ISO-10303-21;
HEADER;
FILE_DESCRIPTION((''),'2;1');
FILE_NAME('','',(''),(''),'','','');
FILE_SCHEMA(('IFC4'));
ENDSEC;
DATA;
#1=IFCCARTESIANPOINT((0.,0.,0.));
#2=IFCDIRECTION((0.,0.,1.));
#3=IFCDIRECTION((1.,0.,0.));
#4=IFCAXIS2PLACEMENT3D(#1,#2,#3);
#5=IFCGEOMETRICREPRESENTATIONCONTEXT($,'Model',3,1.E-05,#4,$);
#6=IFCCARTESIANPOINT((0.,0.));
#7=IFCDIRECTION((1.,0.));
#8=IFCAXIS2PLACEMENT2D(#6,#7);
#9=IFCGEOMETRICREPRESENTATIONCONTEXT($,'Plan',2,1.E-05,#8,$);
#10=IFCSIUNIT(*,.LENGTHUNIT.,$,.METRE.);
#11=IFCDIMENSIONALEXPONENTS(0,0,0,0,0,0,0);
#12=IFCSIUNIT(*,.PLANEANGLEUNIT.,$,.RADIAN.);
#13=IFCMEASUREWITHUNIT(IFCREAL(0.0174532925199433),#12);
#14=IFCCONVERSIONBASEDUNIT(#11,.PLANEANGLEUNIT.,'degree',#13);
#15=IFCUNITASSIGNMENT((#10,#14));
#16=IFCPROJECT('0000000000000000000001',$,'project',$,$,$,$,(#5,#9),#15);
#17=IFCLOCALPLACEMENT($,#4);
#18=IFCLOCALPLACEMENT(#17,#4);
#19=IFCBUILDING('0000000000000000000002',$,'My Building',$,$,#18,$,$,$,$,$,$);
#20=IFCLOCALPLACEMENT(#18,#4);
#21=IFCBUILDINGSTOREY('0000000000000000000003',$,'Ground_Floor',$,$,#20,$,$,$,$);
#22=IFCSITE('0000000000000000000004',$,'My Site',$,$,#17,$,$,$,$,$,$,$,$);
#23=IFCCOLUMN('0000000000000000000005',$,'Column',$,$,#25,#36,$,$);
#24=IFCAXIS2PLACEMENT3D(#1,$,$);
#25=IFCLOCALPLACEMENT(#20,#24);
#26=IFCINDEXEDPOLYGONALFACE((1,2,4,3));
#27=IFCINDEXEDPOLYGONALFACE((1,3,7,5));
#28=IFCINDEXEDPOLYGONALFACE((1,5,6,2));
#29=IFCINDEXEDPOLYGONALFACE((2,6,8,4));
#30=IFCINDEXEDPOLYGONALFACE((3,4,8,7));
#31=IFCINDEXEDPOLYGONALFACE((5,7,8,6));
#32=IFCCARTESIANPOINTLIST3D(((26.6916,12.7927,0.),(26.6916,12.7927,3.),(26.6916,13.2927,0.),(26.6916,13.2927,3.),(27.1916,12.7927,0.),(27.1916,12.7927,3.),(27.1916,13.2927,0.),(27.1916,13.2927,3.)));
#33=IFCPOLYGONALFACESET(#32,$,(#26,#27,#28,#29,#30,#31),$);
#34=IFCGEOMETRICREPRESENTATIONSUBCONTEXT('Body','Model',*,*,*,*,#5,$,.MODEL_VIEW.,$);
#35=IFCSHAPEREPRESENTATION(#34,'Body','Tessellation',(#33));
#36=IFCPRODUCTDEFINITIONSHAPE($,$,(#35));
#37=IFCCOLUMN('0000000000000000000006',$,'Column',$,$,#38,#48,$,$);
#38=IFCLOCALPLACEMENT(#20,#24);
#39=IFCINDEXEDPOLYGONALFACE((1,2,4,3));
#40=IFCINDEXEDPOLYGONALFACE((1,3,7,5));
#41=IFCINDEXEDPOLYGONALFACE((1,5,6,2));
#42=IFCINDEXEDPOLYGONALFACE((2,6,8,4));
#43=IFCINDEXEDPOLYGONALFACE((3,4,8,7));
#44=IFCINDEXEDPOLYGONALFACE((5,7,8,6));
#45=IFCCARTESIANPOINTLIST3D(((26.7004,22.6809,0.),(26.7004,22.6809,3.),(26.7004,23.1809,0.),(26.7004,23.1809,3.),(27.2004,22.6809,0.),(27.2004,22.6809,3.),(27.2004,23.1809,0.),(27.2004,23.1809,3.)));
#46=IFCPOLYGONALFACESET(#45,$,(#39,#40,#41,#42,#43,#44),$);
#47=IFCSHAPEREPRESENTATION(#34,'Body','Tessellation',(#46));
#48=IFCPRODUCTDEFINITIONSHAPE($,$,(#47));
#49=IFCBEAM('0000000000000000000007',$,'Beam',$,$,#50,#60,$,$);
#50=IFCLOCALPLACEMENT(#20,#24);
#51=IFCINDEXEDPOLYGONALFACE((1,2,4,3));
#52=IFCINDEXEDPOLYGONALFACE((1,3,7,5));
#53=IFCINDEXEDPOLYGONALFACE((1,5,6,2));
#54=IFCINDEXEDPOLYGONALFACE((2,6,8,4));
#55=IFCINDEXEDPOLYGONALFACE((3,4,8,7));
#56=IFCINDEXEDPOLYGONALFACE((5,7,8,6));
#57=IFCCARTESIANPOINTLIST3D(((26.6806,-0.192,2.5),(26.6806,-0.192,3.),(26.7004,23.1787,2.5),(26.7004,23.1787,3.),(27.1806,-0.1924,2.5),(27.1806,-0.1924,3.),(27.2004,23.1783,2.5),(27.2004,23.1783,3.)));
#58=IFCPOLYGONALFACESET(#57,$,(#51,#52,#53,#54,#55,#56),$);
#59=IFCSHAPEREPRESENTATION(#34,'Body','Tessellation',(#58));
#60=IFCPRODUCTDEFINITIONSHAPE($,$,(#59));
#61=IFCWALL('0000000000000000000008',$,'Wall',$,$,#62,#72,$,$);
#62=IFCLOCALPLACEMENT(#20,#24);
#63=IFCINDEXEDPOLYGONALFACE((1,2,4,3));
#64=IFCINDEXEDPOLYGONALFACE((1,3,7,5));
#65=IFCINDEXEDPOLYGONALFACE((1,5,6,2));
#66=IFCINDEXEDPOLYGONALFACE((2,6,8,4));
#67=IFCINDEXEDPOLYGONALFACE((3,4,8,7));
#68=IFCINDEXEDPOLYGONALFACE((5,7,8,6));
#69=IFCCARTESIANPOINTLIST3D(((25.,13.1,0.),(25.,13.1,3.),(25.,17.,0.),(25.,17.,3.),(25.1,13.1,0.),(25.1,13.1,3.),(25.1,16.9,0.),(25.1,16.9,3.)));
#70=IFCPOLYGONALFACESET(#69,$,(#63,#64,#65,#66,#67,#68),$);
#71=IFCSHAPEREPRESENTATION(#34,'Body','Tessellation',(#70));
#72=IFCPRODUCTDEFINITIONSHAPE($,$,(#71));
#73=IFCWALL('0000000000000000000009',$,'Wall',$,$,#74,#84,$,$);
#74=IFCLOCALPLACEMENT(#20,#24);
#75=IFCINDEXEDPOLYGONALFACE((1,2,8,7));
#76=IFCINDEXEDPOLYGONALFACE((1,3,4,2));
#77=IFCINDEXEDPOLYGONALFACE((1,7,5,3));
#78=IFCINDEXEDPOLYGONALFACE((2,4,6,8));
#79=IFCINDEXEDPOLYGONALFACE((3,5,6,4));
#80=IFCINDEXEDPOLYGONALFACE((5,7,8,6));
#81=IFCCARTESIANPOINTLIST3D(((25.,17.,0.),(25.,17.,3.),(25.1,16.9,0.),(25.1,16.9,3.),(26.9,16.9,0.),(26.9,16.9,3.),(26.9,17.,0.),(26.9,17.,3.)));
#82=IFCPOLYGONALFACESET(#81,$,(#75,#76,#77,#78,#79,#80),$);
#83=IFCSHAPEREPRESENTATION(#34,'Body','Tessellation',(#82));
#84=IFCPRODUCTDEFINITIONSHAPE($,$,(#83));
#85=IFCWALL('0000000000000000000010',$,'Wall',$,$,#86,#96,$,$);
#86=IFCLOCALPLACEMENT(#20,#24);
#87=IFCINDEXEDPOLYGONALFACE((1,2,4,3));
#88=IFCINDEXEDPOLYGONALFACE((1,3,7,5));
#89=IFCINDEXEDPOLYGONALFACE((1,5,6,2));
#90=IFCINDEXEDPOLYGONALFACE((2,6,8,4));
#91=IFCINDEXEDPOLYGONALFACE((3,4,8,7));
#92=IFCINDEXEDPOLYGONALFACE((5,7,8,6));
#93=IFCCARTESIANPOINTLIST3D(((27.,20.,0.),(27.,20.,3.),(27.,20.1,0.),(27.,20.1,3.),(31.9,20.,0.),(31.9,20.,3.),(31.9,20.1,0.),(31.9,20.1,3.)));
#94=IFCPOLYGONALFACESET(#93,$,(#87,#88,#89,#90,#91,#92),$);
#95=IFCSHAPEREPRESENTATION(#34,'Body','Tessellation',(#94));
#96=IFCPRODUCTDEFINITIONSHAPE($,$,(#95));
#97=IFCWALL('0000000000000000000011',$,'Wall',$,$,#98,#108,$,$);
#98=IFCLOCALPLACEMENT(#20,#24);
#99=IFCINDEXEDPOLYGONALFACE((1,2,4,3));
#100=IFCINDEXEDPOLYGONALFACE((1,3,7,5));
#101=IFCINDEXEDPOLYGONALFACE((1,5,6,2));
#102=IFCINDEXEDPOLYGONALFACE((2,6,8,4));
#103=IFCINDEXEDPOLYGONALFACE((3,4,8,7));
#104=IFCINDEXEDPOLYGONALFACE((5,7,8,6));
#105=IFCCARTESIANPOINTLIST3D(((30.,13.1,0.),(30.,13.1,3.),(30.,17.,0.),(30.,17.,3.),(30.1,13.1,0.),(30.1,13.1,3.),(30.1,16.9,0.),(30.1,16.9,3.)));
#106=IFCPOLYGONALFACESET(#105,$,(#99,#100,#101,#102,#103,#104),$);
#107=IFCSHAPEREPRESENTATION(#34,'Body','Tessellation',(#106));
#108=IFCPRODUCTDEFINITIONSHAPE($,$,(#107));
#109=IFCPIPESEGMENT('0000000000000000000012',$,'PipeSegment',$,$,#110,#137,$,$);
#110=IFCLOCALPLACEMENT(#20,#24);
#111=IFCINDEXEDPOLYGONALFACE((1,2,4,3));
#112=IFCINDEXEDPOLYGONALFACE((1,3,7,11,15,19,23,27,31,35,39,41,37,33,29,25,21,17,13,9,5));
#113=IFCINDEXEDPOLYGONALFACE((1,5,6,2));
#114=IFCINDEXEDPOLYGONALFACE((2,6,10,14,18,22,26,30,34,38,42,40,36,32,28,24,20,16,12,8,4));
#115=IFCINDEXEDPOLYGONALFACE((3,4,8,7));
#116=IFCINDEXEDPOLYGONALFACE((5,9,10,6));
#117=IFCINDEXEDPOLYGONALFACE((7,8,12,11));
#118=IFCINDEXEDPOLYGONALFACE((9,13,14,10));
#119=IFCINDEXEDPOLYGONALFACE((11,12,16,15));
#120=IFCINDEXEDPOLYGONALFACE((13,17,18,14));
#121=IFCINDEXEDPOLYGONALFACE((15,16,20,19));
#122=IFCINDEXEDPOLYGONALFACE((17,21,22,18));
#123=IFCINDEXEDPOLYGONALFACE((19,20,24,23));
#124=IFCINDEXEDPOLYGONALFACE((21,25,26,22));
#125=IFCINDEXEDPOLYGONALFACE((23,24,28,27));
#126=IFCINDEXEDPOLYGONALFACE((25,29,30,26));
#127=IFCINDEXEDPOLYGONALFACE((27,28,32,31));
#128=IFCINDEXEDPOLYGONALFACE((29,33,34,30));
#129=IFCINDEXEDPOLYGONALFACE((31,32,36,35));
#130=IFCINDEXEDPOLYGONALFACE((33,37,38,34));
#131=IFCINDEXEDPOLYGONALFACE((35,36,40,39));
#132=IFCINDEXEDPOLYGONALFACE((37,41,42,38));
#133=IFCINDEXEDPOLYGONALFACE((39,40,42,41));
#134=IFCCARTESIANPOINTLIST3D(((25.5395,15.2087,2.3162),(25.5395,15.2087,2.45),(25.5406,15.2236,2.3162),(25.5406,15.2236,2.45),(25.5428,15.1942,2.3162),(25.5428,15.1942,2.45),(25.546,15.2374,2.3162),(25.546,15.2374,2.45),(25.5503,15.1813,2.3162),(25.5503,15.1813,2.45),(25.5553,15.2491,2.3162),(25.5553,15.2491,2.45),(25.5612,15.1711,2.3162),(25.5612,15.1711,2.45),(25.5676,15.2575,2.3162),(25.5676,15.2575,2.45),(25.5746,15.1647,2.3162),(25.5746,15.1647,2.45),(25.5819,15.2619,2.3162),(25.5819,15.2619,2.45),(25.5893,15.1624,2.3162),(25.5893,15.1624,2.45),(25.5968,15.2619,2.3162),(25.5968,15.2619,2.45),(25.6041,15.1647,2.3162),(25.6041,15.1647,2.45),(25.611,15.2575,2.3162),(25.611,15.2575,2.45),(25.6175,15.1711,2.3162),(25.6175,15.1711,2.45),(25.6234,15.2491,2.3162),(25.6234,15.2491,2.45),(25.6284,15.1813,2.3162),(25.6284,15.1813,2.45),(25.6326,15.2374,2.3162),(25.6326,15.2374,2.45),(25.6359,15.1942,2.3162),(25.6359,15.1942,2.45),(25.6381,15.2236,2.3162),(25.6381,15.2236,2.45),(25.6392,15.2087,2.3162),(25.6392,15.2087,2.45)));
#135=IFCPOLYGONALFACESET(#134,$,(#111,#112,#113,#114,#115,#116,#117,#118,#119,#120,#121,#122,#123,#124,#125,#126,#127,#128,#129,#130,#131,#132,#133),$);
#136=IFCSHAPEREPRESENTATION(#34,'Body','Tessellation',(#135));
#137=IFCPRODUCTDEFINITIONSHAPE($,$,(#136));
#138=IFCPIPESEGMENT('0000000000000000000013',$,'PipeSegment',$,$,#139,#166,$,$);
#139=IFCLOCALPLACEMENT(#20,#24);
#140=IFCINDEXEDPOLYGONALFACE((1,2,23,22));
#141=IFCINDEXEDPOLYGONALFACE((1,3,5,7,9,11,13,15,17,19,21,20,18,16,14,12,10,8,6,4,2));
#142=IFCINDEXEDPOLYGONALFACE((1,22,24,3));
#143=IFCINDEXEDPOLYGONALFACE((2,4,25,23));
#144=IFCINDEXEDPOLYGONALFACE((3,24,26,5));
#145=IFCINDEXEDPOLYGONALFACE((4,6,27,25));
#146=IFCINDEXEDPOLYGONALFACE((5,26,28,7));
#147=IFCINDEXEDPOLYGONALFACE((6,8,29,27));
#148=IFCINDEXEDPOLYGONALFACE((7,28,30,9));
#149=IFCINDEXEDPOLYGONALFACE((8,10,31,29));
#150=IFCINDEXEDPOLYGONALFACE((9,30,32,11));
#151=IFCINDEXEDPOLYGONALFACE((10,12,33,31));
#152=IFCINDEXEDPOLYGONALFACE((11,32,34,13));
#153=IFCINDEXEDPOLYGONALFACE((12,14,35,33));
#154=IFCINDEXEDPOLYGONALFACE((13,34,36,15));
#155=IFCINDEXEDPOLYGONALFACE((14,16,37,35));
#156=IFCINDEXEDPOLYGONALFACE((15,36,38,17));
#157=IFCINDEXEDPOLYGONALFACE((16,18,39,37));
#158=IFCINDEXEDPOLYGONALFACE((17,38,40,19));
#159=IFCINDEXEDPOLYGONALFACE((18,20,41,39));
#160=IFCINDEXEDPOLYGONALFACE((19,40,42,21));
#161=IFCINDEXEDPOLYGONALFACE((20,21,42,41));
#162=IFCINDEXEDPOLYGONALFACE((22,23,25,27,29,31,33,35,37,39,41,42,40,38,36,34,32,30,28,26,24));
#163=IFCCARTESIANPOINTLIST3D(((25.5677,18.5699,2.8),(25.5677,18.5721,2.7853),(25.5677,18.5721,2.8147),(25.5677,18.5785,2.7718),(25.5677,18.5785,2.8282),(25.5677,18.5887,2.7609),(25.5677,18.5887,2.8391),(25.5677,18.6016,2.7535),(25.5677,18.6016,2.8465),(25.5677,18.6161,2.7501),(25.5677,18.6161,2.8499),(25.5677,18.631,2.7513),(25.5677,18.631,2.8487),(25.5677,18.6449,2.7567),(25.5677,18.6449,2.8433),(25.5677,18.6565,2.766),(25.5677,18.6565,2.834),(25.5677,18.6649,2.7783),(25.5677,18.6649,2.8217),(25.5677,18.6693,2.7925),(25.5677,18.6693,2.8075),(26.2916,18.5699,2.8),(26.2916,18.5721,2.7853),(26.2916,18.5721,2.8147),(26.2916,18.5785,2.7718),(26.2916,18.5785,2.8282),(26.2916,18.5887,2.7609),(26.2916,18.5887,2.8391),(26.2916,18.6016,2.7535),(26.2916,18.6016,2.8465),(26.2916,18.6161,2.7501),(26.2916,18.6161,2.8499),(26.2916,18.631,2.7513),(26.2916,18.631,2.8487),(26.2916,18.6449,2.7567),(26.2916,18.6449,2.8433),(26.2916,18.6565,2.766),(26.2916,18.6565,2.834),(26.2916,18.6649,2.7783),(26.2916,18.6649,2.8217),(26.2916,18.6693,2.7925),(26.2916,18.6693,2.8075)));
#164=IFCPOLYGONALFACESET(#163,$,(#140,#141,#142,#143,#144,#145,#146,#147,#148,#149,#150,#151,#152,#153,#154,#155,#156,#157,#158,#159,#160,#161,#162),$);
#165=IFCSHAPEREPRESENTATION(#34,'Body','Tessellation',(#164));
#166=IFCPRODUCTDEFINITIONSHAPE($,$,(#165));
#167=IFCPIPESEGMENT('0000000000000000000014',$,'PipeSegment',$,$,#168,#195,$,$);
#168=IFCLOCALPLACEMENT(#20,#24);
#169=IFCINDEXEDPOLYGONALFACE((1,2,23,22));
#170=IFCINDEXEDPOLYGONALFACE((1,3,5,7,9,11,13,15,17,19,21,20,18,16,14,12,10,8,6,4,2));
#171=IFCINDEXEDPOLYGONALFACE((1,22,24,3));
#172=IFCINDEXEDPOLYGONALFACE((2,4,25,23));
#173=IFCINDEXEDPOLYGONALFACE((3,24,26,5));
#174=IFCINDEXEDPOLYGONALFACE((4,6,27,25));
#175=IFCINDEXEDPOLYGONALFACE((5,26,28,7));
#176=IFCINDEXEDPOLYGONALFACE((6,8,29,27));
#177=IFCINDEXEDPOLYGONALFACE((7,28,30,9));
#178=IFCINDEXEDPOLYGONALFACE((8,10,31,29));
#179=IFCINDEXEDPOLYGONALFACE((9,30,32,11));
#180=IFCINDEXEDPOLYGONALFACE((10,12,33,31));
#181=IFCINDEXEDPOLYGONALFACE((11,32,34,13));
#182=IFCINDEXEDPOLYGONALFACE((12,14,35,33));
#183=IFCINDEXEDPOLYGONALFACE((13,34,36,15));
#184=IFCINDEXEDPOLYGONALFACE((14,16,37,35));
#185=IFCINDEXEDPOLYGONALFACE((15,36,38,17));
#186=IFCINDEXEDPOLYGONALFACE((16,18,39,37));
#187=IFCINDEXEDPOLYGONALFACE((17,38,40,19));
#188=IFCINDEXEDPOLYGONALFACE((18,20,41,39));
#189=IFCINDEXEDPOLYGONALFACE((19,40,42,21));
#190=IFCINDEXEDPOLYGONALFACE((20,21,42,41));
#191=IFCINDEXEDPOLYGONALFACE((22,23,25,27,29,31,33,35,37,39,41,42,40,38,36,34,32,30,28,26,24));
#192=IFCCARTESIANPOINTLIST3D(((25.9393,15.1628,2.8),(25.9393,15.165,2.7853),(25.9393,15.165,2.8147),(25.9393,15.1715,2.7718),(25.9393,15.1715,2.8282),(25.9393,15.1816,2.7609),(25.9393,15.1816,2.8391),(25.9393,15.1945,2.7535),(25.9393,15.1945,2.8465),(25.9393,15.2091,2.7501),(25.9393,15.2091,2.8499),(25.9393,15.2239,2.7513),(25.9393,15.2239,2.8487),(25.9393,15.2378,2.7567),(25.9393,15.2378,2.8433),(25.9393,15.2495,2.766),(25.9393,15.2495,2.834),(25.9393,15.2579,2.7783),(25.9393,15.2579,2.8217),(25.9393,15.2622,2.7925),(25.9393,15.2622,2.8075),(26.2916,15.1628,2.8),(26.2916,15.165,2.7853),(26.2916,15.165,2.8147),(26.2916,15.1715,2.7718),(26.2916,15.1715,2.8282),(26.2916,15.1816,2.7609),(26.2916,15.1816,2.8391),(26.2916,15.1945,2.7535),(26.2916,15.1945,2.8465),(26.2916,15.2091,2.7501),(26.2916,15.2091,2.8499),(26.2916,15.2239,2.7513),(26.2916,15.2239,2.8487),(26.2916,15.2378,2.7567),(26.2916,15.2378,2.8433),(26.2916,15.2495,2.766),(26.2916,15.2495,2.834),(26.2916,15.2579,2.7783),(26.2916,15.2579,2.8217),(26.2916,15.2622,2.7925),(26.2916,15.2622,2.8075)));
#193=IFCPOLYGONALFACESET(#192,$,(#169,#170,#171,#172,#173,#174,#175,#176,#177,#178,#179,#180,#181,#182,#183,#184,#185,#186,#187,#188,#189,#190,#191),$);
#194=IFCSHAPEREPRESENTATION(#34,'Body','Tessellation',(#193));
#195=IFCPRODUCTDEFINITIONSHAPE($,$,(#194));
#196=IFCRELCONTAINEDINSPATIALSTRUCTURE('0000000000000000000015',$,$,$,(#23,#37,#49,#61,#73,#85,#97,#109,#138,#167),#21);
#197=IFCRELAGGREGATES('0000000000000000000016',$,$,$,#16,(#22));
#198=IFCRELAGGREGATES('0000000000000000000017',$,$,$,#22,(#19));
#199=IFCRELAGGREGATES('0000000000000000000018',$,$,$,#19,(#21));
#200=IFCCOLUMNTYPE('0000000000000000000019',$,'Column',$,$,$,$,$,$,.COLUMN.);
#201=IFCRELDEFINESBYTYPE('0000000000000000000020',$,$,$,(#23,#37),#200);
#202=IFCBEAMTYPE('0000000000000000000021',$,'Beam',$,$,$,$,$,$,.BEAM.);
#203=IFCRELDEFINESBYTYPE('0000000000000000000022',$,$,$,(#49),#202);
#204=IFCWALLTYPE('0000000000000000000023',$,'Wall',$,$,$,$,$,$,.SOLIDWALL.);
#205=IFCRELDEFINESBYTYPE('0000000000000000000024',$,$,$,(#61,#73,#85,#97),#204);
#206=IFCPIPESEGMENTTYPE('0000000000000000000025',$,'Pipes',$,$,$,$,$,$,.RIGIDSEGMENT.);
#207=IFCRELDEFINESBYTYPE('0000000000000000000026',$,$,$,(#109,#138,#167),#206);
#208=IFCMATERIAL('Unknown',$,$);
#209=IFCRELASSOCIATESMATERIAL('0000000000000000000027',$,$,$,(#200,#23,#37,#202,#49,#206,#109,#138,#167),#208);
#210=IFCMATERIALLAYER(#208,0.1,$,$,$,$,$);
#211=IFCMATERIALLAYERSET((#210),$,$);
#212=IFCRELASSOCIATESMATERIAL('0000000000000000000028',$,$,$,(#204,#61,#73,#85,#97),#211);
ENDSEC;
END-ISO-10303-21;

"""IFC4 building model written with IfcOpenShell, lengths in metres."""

from ifc_helpers import new_model, entity, si_unit, converted_unit, frame, origin_with_axes, origin_2d_with_axis, place, context, subcontext, project, spatial, line, indexed_curve, rectangle, circle, outline, extrude, material, layer, layer_set, layer_usage, material_profile, profile_set, profile_usage, type_object, element, save


model = new_model("IFC4")

# Units and contexts
model_context = context("Model", 3, precision=1e-05, world=origin_with_axes())
plan_context = context("Plan", 2, precision=1e-05, world=origin_2d_with_axis())
body_context = subcontext(model_context, "Body", "Model", "MODEL_VIEW")
ifc_project = project(units=[si_unit("LENGTHUNIT", "METRE"), converted_unit("PLANEANGLEUNIT", "degree", entity("IfcReal", 0.0174532925199433), si_unit("PLANEANGLEUNIT", "RADIAN"), dimensions=[0, 0, 0, 0, 0, 0, 0])], contexts=[model_context, plan_context])

# Site, building, storey
site_placement = place(None, origin_with_axes())
site = spatial("IfcSite", under=ifc_project, at=site_placement, Name="My Site")
building_placement = place(site_placement, origin_with_axes())
building = spatial("IfcBuilding", under=site, at=building_placement, Name="My Building")
storey_placement = place(building_placement, origin_with_axes())
storey = spatial("IfcBuildingStorey", under=building, at=storey_placement, Name="Ground_Floor")

# Columns
ifc_material = material(Name="Unknown")
ifc_material_profile_1 = material_profile(ifc_material, rectangle(XDim=0.5, YDim=0.5))
ifc_profile_set_1 = profile_set([ifc_material_profile_1])
ifc_profile_usage_1 = profile_usage(ifc_profile_set_1, cardinal=5)
column_type = type_object("IfcColumnType", Name="Column", PredefinedType="COLUMN", material=ifc_profile_set_1)
column_1_placement = place(storey_placement, frame((26.9416, 13.0427, 0.0), z_axis=(0.0, 0.0, 1.0), x_axis=(1.0, 0.0, 0.0)))
element("IfcColumn", 1, at=column_1_placement, inside=storey, type_object=column_type, material=ifc_profile_usage_1, Name="Column", context=body_context, shape_type="SweptSolid", body=[
    extrude(rectangle(XDim=0.5, YDim=0.5), origin_with_axes(), (0.0, 0.0, 1.0), 3.0),
])
ifc_profile_usage_2 = profile_usage(ifc_profile_set_1, cardinal=5)
column_2_placement = place(storey_placement, frame((26.9504, 22.9309, 0.0), z_axis=(0.0, 0.0, 1.0), x_axis=(1.0, 0.0, 0.0)))
element("IfcColumn", 2, at=column_2_placement, inside=storey, type_object=column_type, material=ifc_profile_usage_2, Name="Column", context=body_context, shape_type="SweptSolid", body=[
    extrude(rectangle(XDim=0.5, YDim=0.5), origin_with_axes(), (0.0, 0.0, 1.0), 3.0),
])

# Beam
ifc_material_profile_2 = material_profile(ifc_material, rectangle(XDim=0.5, YDim=0.5))
ifc_profile_set_2 = profile_set([ifc_material_profile_2])
ifc_profile_usage_3 = profile_usage(ifc_profile_set_2, cardinal=5)
beam_type = type_object("IfcBeamType", Name="Beam", PredefinedType="BEAM", material=ifc_profile_set_2)
beam_placement = place(storey_placement, frame((26.9504, 23.1785, 2.75), z_axis=(-0.000849, -1.0, 0.0), x_axis=(1.0, -0.000849, 0.0)))
element("IfcBeam", 3, at=beam_placement, inside=storey, type_object=beam_type, material=ifc_profile_usage_3, Name="Beam", context=body_context, shape_type="SweptSolid", body=[
    extrude(rectangle(XDim=0.5, YDim=0.5), origin_with_axes(), (0.0, 0.0, 1.0), 23.3707),
])

# Walls
ifc_layer = layer(ifc_material, 0.1)
ifc_layer_set = layer_set([ifc_layer])
ifc_layer_usage_1 = layer_usage(ifc_layer_set, "AXIS2", "POSITIVE", 0.0)
wall_type = type_object("IfcWallType", Name="Wall", PredefinedType="SOLIDWALL", material=ifc_layer_set)
wall_1_placement = place(storey_placement, frame((25.0, 17.0, 0.0), z_axis=(0.0, 0.0, 1.0), x_axis=(0.0, -1.0, 0.0)))
element("IfcWall", 4, at=wall_1_placement, inside=storey, type_object=wall_type, material=ifc_layer_usage_1, Name="Wall", context=body_context, shape_type="SweptSolid", body=[
    extrude(outline(indexed_curve([(0.0, 0.0), (0.1, 0.1), (3.9, 0.1), (3.9, 0.0)], segments=[line(1, 2, 3, 4, 1)])), origin_with_axes(), (0.0, 0.0, 1.0), 3.0),
])
ifc_layer_usage_2 = layer_usage(ifc_layer_set, "AXIS2", "POSITIVE", 0.0)
wall_2_placement = place(storey_placement, frame((27.0, 17.0, 0.0), z_axis=(0.0, 0.0, 1.0), x_axis=(-1.0, 0.0, 0.0)))
element("IfcWall", 5, at=wall_2_placement, inside=storey, type_object=wall_type, material=ifc_layer_usage_2, Name="Wall", context=body_context, shape_type="SweptSolid", body=[
    extrude(outline(indexed_curve([(0.1, 0.0), (0.1, 0.1), (1.9, 0.1), (2.0, 0.0)], segments=[line(1, 2, 3, 4, 1)])), origin_with_axes(), (0.0, 0.0, 1.0), 3.0),
])
ifc_layer_usage_3 = layer_usage(ifc_layer_set, "AXIS2", "POSITIVE", 0.0)
wall_3_placement = place(storey_placement, frame((27.0, 20.0, 0.0), z_axis=(0.0, 0.0, 1.0), x_axis=(1.0, 0.0, 0.0)))
element("IfcWall", 6, at=wall_3_placement, inside=storey, type_object=wall_type, material=ifc_layer_usage_3, Name="Wall", context=body_context, shape_type="SweptSolid", body=[
    extrude(outline(indexed_curve([(0.0, 0.0), (0.0, 0.1), (4.9, 0.1), (4.9, 0.0)], segments=[line(1, 2, 3, 4, 1)])), origin_with_axes(), (0.0, 0.0, 1.0), 3.0),
])
ifc_layer_usage_4 = layer_usage(ifc_layer_set, "AXIS2", "POSITIVE", 0.0)
wall_4_placement = place(storey_placement, frame((30.0, 17.0, 0.0), z_axis=(0.0, 0.0, 1.0), x_axis=(0.0, -1.0, 0.0)))
element("IfcWall", 7, at=wall_4_placement, inside=storey, type_object=wall_type, material=ifc_layer_usage_4, Name="Wall", context=body_context, shape_type="SweptSolid", body=[
    extrude(outline(indexed_curve([(0.0, 0.0), (0.1, 0.1), (3.9, 0.1), (3.9, 0.0)], segments=[line(1, 2, 3, 4, 1)])), origin_with_axes(), (0.0, 0.0, 1.0), 3.0),
])

# Pipe segments
ifc_material_profile_3 = material_profile(ifc_material, circle(Radius=0.05))
ifc_profile_set_3 = profile_set([ifc_material_profile_3])
ifc_profile_usage_4 = profile_usage(ifc_profile_set_3, cardinal=5)
pipe_segment_type = type_object("IfcPipeSegmentType", Name="Pipes", PredefinedType="RIGIDSEGMENT", material=ifc_profile_set_3)
pipe_segment_1_placement = place(storey_placement, frame((25.5893, 15.2124, 2.45), z_axis=(0.0, 0.0, -1.0), x_axis=(0.0, -1.0, 0.0)))
element("IfcPipeSegment", 8, at=pipe_segment_1_placement, inside=storey, type_object=pipe_segment_type, material=ifc_profile_usage_4, Name="PipeSegment", context=body_context, shape_type="SweptSolid", body=[
    extrude(circle(Radius=0.05), origin_with_axes(), (0.0, 0.0, 1.0), 0.1338),
])
ifc_profile_usage_5 = profile_usage(ifc_profile_set_3, cardinal=5)
pipe_segment_2_placement = place(storey_placement, frame((26.2916, 18.6199, 2.8), z_axis=(-1.0, 0.0, 0.0), x_axis=(0.0, -1.0, 0.0)))
element("IfcPipeSegment", 9, at=pipe_segment_2_placement, inside=storey, type_object=pipe_segment_type, material=ifc_profile_usage_5, Name="PipeSegment", context=body_context, shape_type="SweptSolid", body=[
    extrude(circle(Radius=0.05), origin_with_axes(), (0.0, 0.0, 1.0), 0.7239),
])
ifc_profile_usage_6 = profile_usage(ifc_profile_set_3, cardinal=5)
pipe_segment_3_placement = place(storey_placement, frame((26.2916, 15.2128, 2.8), z_axis=(-1.0, 0.0, 0.0), x_axis=(0.0, -1.0, 0.0)))
element("IfcPipeSegment", 10, at=pipe_segment_3_placement, inside=storey, type_object=pipe_segment_type, material=ifc_profile_usage_6, Name="PipeSegment", context=body_context, shape_type="SweptSolid", body=[
    extrude(circle(Radius=0.05), origin_with_axes(), (0.0, 0.0, 1.0), 0.3523),
])

save(model, "model.ifc")
